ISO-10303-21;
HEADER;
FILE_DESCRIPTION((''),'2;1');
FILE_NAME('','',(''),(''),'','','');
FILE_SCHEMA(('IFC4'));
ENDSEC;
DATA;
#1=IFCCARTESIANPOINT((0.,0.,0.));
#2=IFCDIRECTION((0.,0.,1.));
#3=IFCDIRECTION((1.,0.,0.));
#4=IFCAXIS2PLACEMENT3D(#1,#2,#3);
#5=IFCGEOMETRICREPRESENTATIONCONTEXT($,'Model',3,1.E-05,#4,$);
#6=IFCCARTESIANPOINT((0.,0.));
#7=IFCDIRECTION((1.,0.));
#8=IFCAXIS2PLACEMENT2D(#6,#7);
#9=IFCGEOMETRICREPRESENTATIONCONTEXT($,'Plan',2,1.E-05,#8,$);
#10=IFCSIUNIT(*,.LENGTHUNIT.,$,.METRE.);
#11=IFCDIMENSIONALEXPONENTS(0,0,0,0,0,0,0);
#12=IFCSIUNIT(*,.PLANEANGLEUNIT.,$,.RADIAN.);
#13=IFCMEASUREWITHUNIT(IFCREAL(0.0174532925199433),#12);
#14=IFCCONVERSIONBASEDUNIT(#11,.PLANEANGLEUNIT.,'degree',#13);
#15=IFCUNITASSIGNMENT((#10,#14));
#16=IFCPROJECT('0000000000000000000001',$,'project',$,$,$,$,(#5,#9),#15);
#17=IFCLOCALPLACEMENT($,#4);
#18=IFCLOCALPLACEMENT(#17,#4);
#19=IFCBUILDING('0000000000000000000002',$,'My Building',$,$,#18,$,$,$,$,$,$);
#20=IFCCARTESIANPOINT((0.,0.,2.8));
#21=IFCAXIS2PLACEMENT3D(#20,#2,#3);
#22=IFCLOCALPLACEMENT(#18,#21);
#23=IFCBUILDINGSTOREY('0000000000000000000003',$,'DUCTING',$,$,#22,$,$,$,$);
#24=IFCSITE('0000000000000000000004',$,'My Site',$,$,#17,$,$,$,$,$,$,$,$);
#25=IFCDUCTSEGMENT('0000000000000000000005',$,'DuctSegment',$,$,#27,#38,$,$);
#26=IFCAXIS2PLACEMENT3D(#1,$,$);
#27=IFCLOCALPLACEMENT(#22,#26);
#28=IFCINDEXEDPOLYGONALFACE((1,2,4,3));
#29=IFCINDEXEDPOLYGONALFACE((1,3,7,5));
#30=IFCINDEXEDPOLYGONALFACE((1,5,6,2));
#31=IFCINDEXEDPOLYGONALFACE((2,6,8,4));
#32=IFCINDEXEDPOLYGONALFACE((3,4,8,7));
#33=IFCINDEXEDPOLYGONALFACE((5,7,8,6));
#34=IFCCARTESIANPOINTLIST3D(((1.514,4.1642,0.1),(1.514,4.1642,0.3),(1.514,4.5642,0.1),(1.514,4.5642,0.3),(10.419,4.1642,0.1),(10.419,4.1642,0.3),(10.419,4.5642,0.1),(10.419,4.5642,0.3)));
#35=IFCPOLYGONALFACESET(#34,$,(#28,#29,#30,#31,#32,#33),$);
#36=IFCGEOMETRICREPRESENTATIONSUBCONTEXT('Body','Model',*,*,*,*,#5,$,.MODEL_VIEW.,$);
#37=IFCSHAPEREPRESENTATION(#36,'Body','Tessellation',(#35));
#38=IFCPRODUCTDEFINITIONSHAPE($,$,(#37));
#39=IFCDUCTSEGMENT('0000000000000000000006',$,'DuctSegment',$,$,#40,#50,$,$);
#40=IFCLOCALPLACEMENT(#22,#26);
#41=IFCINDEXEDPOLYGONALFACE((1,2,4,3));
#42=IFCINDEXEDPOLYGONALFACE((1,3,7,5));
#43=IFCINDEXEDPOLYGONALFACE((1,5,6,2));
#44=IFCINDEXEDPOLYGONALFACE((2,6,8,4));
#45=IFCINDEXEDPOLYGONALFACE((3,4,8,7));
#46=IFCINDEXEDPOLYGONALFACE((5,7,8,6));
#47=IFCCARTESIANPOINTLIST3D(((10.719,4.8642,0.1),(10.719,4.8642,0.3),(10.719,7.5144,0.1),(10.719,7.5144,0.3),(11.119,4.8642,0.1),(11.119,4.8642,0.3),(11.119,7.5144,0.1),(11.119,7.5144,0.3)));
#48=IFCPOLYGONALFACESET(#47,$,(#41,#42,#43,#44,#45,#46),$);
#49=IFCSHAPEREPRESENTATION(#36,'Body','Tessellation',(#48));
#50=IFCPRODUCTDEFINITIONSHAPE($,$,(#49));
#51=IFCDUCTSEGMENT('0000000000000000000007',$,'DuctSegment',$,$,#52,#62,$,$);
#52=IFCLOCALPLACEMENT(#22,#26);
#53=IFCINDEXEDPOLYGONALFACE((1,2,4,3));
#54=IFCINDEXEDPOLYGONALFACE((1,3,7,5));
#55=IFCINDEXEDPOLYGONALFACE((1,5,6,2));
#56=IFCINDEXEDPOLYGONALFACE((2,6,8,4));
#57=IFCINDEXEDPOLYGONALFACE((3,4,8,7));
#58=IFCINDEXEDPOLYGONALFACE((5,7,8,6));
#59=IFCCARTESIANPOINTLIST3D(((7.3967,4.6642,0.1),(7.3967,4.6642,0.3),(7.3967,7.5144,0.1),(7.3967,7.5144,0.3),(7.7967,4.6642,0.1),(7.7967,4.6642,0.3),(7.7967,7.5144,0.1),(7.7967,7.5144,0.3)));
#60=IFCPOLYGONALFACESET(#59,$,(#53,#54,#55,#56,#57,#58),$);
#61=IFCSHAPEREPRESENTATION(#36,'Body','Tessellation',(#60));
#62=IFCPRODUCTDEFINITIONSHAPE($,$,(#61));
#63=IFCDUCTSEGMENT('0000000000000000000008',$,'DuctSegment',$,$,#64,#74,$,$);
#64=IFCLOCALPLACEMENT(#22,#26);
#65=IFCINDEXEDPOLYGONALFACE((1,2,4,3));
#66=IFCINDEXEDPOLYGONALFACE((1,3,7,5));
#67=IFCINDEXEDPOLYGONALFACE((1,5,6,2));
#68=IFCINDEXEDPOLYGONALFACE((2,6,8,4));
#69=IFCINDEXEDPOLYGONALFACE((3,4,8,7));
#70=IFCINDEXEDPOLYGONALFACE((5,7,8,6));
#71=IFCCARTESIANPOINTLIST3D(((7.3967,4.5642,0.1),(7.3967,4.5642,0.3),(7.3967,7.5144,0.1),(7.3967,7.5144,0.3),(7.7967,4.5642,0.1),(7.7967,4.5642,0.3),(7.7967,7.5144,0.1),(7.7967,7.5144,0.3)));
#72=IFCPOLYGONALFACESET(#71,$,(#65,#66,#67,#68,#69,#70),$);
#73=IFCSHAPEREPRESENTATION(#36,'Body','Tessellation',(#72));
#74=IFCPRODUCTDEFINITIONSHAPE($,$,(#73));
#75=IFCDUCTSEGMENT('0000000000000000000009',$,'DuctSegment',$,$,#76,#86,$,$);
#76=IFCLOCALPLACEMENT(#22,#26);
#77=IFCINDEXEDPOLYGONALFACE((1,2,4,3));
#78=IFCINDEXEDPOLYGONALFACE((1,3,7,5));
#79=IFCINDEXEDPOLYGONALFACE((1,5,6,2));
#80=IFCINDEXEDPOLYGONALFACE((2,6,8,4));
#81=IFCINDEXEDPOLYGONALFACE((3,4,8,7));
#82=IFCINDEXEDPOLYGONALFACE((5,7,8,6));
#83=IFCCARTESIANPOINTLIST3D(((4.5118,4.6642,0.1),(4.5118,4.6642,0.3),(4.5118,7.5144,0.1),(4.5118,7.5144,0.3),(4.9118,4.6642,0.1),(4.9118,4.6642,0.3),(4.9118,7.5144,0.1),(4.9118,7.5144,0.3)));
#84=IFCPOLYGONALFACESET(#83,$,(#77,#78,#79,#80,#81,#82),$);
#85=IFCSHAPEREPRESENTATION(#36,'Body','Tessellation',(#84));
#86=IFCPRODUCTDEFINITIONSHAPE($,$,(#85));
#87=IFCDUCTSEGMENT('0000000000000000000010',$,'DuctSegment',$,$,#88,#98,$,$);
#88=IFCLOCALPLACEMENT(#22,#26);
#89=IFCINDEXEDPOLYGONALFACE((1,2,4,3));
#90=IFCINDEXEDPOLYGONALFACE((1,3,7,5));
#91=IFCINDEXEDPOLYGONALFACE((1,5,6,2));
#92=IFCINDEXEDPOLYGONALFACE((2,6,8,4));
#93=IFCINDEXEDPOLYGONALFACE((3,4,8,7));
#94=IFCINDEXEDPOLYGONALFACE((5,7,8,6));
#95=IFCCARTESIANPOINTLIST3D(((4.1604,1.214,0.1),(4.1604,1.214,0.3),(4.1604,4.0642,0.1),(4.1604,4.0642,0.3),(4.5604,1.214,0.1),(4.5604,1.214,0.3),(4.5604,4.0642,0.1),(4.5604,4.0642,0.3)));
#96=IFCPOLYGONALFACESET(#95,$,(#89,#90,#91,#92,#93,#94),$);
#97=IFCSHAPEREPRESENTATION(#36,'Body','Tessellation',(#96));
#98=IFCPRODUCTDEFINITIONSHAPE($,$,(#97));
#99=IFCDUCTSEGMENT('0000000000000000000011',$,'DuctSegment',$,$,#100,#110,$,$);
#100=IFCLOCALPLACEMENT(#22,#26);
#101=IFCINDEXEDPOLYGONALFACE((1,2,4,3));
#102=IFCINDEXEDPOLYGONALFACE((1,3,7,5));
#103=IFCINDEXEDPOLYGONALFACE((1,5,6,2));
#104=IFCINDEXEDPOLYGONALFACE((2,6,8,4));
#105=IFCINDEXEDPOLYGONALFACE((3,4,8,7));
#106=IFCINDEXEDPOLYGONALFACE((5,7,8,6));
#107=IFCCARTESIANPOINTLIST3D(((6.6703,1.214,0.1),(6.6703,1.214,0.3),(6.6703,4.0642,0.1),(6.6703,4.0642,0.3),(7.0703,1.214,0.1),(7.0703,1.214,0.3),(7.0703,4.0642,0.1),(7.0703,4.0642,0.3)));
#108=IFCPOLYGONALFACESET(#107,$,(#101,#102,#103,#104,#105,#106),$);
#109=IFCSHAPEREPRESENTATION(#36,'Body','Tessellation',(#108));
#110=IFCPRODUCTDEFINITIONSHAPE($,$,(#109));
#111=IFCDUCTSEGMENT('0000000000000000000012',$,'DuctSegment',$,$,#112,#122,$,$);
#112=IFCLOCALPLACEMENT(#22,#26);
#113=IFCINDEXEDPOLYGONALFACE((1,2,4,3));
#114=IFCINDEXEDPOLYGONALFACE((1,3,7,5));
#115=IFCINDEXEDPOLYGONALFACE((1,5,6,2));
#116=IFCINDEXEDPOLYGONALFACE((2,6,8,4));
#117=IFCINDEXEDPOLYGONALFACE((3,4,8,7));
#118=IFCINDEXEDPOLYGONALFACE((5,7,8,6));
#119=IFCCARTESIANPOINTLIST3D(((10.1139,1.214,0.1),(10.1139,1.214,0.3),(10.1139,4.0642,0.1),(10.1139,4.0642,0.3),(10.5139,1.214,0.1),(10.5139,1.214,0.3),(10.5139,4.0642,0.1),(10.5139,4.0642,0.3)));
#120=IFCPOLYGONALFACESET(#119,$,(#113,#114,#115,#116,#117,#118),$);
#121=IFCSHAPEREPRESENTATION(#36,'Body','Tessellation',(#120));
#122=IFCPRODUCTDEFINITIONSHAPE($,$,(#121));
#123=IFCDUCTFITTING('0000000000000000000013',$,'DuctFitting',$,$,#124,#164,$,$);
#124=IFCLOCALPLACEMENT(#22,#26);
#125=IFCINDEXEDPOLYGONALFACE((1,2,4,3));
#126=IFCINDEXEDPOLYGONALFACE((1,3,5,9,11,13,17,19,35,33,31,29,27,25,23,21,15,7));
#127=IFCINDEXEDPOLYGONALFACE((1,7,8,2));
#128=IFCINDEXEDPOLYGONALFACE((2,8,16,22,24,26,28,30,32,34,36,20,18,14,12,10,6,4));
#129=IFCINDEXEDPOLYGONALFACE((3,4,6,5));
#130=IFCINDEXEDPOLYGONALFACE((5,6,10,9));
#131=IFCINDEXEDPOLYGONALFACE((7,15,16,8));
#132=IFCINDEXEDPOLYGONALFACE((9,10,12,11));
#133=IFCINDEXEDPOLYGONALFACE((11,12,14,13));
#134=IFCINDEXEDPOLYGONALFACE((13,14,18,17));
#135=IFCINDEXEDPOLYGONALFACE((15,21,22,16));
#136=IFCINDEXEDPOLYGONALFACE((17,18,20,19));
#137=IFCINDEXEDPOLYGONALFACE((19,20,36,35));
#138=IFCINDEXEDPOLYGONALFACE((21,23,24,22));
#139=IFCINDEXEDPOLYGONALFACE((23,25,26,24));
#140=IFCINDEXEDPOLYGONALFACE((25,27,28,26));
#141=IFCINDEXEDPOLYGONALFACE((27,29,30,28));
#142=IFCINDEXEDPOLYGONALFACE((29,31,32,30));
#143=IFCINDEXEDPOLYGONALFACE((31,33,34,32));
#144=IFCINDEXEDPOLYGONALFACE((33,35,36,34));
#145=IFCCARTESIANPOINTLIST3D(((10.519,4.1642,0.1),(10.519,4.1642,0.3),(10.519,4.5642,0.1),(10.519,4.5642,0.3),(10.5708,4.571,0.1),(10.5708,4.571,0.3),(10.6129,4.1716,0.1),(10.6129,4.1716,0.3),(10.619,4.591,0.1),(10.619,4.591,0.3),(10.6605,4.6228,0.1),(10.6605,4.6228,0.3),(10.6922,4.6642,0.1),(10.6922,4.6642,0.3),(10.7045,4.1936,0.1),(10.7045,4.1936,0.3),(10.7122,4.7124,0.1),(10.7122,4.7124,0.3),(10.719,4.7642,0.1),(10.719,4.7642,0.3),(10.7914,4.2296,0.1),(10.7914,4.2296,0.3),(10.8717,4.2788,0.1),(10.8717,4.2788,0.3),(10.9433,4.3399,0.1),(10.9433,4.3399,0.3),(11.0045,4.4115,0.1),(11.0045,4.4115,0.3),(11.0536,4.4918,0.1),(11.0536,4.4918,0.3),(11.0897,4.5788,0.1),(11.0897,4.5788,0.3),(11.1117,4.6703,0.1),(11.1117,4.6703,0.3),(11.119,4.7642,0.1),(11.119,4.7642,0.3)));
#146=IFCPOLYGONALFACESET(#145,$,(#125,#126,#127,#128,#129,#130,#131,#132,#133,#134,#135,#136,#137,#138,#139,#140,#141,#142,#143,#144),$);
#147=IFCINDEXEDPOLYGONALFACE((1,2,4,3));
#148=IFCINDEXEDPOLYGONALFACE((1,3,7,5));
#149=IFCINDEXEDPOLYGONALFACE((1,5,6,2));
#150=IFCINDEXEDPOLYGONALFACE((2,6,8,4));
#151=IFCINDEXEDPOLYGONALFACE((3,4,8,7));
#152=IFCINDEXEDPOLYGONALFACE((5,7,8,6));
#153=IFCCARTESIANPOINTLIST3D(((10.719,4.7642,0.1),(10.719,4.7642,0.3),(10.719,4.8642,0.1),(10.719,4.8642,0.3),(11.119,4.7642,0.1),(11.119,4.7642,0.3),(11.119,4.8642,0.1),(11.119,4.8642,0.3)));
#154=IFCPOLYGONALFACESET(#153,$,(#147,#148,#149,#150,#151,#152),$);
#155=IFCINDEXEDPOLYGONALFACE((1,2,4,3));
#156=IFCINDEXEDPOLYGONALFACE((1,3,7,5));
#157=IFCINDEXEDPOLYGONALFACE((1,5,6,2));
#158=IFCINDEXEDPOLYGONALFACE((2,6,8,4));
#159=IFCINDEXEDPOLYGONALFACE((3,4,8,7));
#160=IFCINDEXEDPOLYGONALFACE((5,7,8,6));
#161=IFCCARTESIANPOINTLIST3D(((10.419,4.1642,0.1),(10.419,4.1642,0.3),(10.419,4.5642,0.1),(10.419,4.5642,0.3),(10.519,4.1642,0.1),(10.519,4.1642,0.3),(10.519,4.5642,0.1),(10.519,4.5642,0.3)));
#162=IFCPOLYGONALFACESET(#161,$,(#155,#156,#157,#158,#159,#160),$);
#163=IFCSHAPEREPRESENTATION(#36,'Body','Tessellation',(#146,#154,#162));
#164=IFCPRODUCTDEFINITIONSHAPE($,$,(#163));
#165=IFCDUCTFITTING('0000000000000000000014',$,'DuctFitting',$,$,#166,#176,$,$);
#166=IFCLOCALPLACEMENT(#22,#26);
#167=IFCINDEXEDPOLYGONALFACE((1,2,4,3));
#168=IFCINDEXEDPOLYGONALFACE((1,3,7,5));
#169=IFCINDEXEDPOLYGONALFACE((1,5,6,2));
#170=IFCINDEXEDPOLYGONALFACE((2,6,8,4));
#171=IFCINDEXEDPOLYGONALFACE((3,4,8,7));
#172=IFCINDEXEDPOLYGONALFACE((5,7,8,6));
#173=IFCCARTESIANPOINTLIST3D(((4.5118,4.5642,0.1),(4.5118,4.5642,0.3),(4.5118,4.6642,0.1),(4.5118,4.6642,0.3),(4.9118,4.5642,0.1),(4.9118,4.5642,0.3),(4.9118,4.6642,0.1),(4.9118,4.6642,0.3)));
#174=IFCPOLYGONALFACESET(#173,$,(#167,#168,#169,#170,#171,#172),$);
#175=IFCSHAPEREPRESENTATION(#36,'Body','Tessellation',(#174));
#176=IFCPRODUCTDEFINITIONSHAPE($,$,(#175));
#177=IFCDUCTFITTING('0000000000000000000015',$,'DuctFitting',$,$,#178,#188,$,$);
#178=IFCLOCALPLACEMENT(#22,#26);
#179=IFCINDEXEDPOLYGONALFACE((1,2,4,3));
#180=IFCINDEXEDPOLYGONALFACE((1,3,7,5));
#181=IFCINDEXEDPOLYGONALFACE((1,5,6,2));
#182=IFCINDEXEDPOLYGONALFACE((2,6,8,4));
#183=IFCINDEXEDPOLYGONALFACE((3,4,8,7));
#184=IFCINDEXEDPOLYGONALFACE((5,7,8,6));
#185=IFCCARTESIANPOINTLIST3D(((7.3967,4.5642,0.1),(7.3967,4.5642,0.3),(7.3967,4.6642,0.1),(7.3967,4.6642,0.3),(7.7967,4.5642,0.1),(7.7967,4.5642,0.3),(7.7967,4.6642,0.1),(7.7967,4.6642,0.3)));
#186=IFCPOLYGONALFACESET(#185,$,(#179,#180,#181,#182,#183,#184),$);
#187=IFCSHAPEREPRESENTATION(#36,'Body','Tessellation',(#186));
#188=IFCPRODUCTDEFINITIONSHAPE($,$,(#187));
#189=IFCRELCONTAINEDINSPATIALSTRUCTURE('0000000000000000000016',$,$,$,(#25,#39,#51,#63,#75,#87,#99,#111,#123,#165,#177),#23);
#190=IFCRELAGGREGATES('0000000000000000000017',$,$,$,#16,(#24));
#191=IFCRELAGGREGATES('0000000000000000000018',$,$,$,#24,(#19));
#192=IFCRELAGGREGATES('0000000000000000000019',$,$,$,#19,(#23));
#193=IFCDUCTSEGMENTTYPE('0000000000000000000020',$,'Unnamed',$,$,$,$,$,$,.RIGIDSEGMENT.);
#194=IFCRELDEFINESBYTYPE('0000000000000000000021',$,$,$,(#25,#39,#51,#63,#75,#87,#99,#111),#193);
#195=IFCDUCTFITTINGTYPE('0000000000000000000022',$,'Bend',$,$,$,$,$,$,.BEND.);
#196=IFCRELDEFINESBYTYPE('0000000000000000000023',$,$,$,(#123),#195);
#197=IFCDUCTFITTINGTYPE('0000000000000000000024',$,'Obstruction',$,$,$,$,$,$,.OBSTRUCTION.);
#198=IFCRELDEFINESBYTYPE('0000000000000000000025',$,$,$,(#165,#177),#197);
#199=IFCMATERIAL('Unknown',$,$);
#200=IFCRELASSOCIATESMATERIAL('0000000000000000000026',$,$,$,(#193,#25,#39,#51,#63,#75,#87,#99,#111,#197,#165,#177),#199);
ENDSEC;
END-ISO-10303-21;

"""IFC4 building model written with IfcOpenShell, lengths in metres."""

from ifc_helpers import new_model, entity, si_unit, converted_unit, frame, origin_with_axes, origin_2d_with_axis, place, context, subcontext, project, spatial, line, arc, indexed_curve, rectangle, outline, extrude, source, transform, mapped, material, material_profile, profile_set, profile_usage, type_object, type_shapes, element, save


model = new_model("IFC4")

# Units and contexts
model_context = context("Model", 3, precision=1e-05, world=origin_with_axes())
plan_context = context("Plan", 2, precision=1e-05, world=origin_2d_with_axis())
body_context = subcontext(model_context, "Body", "Model", "MODEL_VIEW")
ifc_project = project(units=[si_unit("LENGTHUNIT", "METRE"), converted_unit("PLANEANGLEUNIT", "degree", entity("IfcReal", 0.0174532925199433), si_unit("PLANEANGLEUNIT", "RADIAN"), dimensions=[0, 0, 0, 0, 0, 0, 0])], contexts=[model_context, plan_context])

# Site, building, storey
site_placement = place(None, origin_with_axes())
site = spatial("IfcSite", under=ifc_project, at=site_placement, Name="My Site")
building_placement = place(site_placement, origin_with_axes())
building = spatial("IfcBuilding", under=site, at=building_placement, Name="My Building")
storey_placement = place(building_placement, frame((0.0, 0.0, 2.8), z_axis=(0.0, 0.0, 1.0), x_axis=(1.0, 0.0, 0.0)))
storey = spatial("IfcBuildingStorey", under=building, at=storey_placement, Name="DUCTING")

# Duct segments
ifc_material = material(Name="Unknown")
ifc_material_profile_1 = material_profile(ifc_material, rectangle(XDim=0.4, YDim=0.2))
ifc_profile_set_1 = profile_set([ifc_material_profile_1])
ifc_profile_usage_1 = profile_usage(ifc_profile_set_1, cardinal=5)
duct_segment_type = type_object("IfcDuctSegmentType", Name="Unnamed", PredefinedType="RIGIDSEGMENT", material=ifc_profile_set_1)
duct_segment_1_placement = place(storey_placement, frame((1.514, 4.3642, 0.2), z_axis=(1.0, 0.0, 0.0), x_axis=(0.0, 1.0, 0.0)))
element("IfcDuctSegment", 1, at=duct_segment_1_placement, inside=storey, type_object=duct_segment_type, material=ifc_profile_usage_1, Name="DuctSegment", context=body_context, shape_type="SweptSolid", body=[
    extrude(rectangle(XDim=0.4, YDim=0.2), origin_with_axes(), (0.0, 0.0, 1.0), 8.9051),
])
ifc_profile_usage_2 = profile_usage(ifc_profile_set_1, cardinal=5)
duct_segment_2_placement = place(storey_placement, frame((10.919, 4.8642, 0.2), z_axis=(0.0, 1.0, 0.0), x_axis=(-1.0, 0.0, 0.0)))
element("IfcDuctSegment", 2, at=duct_segment_2_placement, inside=storey, type_object=duct_segment_type, material=ifc_profile_usage_2, Name="DuctSegment", context=body_context, shape_type="SweptSolid", body=[
    extrude(rectangle(XDim=0.4, YDim=0.2), origin_with_axes(), (0.0, 0.0, 1.0), 2.6502),
])
ifc_profile_usage_3 = profile_usage(ifc_profile_set_1, cardinal=5)
duct_segment_3_placement = place(storey_placement, frame((7.5967, 4.6642, 0.2), z_axis=(0.0, 1.0, 0.0), x_axis=(-1.0, 0.0, 0.0)))
element("IfcDuctSegment", 3, at=duct_segment_3_placement, inside=storey, type_object=duct_segment_type, material=ifc_profile_usage_3, Name="DuctSegment", context=body_context, shape_type="SweptSolid", body=[
    extrude(rectangle(XDim=0.4, YDim=0.2), origin_with_axes(), (0.0, 0.0, 1.0), 2.8502),
])
ifc_profile_usage_4 = profile_usage(ifc_profile_set_1, cardinal=5)
duct_segment_4_placement = place(storey_placement, frame((7.5967, 4.5642, 0.2), z_axis=(0.0, 1.0, 0.0), x_axis=(-1.0, 0.0, 0.0)))
element("IfcDuctSegment", 4, at=duct_segment_4_placement, inside=storey, type_object=duct_segment_type, material=ifc_profile_usage_4, Name="DuctSegment", context=body_context, shape_type="SweptSolid", body=[
    extrude(rectangle(XDim=0.4, YDim=0.2), origin_with_axes(), (0.0, 0.0, 1.0), 2.9502),
])
ifc_profile_usage_5 = profile_usage(ifc_profile_set_1, cardinal=5)
duct_segment_5_placement = place(storey_placement, frame((4.7118, 4.6642, 0.2), z_axis=(0.0, 1.0, 0.0), x_axis=(-1.0, 0.0, 0.0)))
element("IfcDuctSegment", 5, at=duct_segment_5_placement, inside=storey, type_object=duct_segment_type, material=ifc_profile_usage_5, Name="DuctSegment", context=body_context, shape_type="SweptSolid", body=[
    extrude(rectangle(XDim=0.4, YDim=0.2), origin_with_axes(), (0.0, 0.0, 1.0), 2.8502),
])
ifc_profile_usage_6 = profile_usage(ifc_profile_set_1, cardinal=5)
duct_segment_6_placement = place(storey_placement, frame((4.3604, 4.0642, 0.2), z_axis=(0.0, -1.0, 0.0), x_axis=(1.0, 0.0, 0.0)))
element("IfcDuctSegment", 6, at=duct_segment_6_placement, inside=storey, type_object=duct_segment_type, material=ifc_profile_usage_6, Name="DuctSegment", context=body_context, shape_type="SweptSolid", body=[
    extrude(rectangle(XDim=0.4, YDim=0.2), origin_with_axes(), (0.0, 0.0, 1.0), 2.8502),
])
ifc_profile_usage_7 = profile_usage(ifc_profile_set_1, cardinal=5)
duct_segment_7_placement = place(storey_placement, frame((6.8703, 4.0642, 0.2), z_axis=(0.0, -1.0, 0.0), x_axis=(1.0, 0.0, 0.0)))
element("IfcDuctSegment", 7, at=duct_segment_7_placement, inside=storey, type_object=duct_segment_type, material=ifc_profile_usage_7, Name="DuctSegment", context=body_context, shape_type="SweptSolid", body=[
    extrude(rectangle(XDim=0.4, YDim=0.2), origin_with_axes(), (0.0, 0.0, 1.0), 2.8502),
])
ifc_profile_usage_8 = profile_usage(ifc_profile_set_1, cardinal=5)
duct_segment_8_placement = place(storey_placement, frame((10.3139, 4.0642, 0.2), z_axis=(0.0, -1.0, 0.0), x_axis=(1.0, 0.0, 0.0)))
element("IfcDuctSegment", 8, at=duct_segment_8_placement, inside=storey, type_object=duct_segment_type, material=ifc_profile_usage_8, Name="DuctSegment", context=body_context, shape_type="SweptSolid", body=[
    extrude(rectangle(XDim=0.4, YDim=0.2), origin_with_axes(), (0.0, 0.0, 1.0), 2.8502),
])

# Duct fittings
duct_fitting_type_1 = type_object("IfcDuctFittingType", Name="Bend", PredefinedType="BEND")
shared_shape = source(origin_with_axes(), body_context, "Body", "SweptSolid", [
    extrude(outline(indexed_curve([(0.2, 0.0), (0.2586, -0.1414), (0.4, -0.2), (0.4, -0.6), (-0.0243, -0.4243), (-0.2, 0.0)], segments=[arc(1, 2, 3), line(3, 4), arc(4, 5, 6), line(6, 1)])), frame((0.0, -0.1, -0.1), z_axis=(0.0, -1.0, 0.0), x_axis=(1.0, 0.0, 0.0)), (0.0, 0.0, -1.0), 0.2),
    extrude(rectangle(XDim=0.4, YDim=0.2), origin_with_axes(), (0.0, 0.0, -1.0), 0.1),
    extrude(rectangle(XDim=0.4, YDim=0.2), frame((0.4, 0.0, -0.5), z_axis=(1.0, 0.0, 0.0), x_axis=(0.0, 0.0, 1.0)), (0.0, 0.0, 1.0), 0.1),
])
type_shapes(duct_fitting_type_1, [shared_shape])
duct_fitting_1_placement = place(storey_placement, frame((10.919, 4.8642, 0.2), z_axis=(0.0, 1.0, 0.0), x_axis=(-1.0, 0.0, 0.0)))
element("IfcDuctFitting", 9, at=duct_fitting_1_placement, inside=storey, type_object=duct_fitting_type_1, Name="DuctFitting", context=body_context, shape_type="MappedRepresentation", body=[
    mapped(shared_shape, transform((0.0, 0.0, 0.0), x_axis=(1.0, 0.0, 0.0), y_axis=(0.0, 1.0, 0.0), z_axis=(0.0, 0.0, 1.0), scale=1.0)),
])
ifc_material_profile_2 = material_profile(ifc_material, rectangle(XDim=0.4, YDim=0.2))
ifc_profile_set_2 = profile_set([ifc_material_profile_2])
ifc_profile_usage_9 = profile_usage(ifc_profile_set_2, cardinal=5)
duct_fitting_type_2 = type_object("IfcDuctFittingType", Name="Obstruction", PredefinedType="OBSTRUCTION", material=ifc_profile_set_2)
duct_fitting_2_placement = place(storey_placement, frame((4.7118, 4.5642, 0.2), z_axis=(0.0, 1.0, 0.0), x_axis=(-1.0, 0.0, 0.0)))
element("IfcDuctFitting", 10, at=duct_fitting_2_placement, inside=storey, type_object=duct_fitting_type_2, material=ifc_profile_usage_9, Name="DuctFitting", context=body_context, shape_type="SweptSolid", body=[
    extrude(rectangle(XDim=0.4, YDim=0.2), origin_with_axes(), (0.0, 0.0, 1.0), 0.1),
])
ifc_profile_usage_10 = profile_usage(ifc_profile_set_2, cardinal=5)
duct_fitting_3_placement = place(storey_placement, frame((7.5967, 4.5642, 0.2), z_axis=(0.0, 1.0, 0.0), x_axis=(-1.0, 0.0, 0.0)))
element("IfcDuctFitting", 11, at=duct_fitting_3_placement, inside=storey, type_object=duct_fitting_type_2, material=ifc_profile_usage_10, Name="DuctFitting", context=body_context, shape_type="SweptSolid", body=[
    extrude(rectangle(XDim=0.4, YDim=0.2), origin_with_axes(), (0.0, 0.0, 1.0), 0.1),
])

save(model, "model.ifc")
